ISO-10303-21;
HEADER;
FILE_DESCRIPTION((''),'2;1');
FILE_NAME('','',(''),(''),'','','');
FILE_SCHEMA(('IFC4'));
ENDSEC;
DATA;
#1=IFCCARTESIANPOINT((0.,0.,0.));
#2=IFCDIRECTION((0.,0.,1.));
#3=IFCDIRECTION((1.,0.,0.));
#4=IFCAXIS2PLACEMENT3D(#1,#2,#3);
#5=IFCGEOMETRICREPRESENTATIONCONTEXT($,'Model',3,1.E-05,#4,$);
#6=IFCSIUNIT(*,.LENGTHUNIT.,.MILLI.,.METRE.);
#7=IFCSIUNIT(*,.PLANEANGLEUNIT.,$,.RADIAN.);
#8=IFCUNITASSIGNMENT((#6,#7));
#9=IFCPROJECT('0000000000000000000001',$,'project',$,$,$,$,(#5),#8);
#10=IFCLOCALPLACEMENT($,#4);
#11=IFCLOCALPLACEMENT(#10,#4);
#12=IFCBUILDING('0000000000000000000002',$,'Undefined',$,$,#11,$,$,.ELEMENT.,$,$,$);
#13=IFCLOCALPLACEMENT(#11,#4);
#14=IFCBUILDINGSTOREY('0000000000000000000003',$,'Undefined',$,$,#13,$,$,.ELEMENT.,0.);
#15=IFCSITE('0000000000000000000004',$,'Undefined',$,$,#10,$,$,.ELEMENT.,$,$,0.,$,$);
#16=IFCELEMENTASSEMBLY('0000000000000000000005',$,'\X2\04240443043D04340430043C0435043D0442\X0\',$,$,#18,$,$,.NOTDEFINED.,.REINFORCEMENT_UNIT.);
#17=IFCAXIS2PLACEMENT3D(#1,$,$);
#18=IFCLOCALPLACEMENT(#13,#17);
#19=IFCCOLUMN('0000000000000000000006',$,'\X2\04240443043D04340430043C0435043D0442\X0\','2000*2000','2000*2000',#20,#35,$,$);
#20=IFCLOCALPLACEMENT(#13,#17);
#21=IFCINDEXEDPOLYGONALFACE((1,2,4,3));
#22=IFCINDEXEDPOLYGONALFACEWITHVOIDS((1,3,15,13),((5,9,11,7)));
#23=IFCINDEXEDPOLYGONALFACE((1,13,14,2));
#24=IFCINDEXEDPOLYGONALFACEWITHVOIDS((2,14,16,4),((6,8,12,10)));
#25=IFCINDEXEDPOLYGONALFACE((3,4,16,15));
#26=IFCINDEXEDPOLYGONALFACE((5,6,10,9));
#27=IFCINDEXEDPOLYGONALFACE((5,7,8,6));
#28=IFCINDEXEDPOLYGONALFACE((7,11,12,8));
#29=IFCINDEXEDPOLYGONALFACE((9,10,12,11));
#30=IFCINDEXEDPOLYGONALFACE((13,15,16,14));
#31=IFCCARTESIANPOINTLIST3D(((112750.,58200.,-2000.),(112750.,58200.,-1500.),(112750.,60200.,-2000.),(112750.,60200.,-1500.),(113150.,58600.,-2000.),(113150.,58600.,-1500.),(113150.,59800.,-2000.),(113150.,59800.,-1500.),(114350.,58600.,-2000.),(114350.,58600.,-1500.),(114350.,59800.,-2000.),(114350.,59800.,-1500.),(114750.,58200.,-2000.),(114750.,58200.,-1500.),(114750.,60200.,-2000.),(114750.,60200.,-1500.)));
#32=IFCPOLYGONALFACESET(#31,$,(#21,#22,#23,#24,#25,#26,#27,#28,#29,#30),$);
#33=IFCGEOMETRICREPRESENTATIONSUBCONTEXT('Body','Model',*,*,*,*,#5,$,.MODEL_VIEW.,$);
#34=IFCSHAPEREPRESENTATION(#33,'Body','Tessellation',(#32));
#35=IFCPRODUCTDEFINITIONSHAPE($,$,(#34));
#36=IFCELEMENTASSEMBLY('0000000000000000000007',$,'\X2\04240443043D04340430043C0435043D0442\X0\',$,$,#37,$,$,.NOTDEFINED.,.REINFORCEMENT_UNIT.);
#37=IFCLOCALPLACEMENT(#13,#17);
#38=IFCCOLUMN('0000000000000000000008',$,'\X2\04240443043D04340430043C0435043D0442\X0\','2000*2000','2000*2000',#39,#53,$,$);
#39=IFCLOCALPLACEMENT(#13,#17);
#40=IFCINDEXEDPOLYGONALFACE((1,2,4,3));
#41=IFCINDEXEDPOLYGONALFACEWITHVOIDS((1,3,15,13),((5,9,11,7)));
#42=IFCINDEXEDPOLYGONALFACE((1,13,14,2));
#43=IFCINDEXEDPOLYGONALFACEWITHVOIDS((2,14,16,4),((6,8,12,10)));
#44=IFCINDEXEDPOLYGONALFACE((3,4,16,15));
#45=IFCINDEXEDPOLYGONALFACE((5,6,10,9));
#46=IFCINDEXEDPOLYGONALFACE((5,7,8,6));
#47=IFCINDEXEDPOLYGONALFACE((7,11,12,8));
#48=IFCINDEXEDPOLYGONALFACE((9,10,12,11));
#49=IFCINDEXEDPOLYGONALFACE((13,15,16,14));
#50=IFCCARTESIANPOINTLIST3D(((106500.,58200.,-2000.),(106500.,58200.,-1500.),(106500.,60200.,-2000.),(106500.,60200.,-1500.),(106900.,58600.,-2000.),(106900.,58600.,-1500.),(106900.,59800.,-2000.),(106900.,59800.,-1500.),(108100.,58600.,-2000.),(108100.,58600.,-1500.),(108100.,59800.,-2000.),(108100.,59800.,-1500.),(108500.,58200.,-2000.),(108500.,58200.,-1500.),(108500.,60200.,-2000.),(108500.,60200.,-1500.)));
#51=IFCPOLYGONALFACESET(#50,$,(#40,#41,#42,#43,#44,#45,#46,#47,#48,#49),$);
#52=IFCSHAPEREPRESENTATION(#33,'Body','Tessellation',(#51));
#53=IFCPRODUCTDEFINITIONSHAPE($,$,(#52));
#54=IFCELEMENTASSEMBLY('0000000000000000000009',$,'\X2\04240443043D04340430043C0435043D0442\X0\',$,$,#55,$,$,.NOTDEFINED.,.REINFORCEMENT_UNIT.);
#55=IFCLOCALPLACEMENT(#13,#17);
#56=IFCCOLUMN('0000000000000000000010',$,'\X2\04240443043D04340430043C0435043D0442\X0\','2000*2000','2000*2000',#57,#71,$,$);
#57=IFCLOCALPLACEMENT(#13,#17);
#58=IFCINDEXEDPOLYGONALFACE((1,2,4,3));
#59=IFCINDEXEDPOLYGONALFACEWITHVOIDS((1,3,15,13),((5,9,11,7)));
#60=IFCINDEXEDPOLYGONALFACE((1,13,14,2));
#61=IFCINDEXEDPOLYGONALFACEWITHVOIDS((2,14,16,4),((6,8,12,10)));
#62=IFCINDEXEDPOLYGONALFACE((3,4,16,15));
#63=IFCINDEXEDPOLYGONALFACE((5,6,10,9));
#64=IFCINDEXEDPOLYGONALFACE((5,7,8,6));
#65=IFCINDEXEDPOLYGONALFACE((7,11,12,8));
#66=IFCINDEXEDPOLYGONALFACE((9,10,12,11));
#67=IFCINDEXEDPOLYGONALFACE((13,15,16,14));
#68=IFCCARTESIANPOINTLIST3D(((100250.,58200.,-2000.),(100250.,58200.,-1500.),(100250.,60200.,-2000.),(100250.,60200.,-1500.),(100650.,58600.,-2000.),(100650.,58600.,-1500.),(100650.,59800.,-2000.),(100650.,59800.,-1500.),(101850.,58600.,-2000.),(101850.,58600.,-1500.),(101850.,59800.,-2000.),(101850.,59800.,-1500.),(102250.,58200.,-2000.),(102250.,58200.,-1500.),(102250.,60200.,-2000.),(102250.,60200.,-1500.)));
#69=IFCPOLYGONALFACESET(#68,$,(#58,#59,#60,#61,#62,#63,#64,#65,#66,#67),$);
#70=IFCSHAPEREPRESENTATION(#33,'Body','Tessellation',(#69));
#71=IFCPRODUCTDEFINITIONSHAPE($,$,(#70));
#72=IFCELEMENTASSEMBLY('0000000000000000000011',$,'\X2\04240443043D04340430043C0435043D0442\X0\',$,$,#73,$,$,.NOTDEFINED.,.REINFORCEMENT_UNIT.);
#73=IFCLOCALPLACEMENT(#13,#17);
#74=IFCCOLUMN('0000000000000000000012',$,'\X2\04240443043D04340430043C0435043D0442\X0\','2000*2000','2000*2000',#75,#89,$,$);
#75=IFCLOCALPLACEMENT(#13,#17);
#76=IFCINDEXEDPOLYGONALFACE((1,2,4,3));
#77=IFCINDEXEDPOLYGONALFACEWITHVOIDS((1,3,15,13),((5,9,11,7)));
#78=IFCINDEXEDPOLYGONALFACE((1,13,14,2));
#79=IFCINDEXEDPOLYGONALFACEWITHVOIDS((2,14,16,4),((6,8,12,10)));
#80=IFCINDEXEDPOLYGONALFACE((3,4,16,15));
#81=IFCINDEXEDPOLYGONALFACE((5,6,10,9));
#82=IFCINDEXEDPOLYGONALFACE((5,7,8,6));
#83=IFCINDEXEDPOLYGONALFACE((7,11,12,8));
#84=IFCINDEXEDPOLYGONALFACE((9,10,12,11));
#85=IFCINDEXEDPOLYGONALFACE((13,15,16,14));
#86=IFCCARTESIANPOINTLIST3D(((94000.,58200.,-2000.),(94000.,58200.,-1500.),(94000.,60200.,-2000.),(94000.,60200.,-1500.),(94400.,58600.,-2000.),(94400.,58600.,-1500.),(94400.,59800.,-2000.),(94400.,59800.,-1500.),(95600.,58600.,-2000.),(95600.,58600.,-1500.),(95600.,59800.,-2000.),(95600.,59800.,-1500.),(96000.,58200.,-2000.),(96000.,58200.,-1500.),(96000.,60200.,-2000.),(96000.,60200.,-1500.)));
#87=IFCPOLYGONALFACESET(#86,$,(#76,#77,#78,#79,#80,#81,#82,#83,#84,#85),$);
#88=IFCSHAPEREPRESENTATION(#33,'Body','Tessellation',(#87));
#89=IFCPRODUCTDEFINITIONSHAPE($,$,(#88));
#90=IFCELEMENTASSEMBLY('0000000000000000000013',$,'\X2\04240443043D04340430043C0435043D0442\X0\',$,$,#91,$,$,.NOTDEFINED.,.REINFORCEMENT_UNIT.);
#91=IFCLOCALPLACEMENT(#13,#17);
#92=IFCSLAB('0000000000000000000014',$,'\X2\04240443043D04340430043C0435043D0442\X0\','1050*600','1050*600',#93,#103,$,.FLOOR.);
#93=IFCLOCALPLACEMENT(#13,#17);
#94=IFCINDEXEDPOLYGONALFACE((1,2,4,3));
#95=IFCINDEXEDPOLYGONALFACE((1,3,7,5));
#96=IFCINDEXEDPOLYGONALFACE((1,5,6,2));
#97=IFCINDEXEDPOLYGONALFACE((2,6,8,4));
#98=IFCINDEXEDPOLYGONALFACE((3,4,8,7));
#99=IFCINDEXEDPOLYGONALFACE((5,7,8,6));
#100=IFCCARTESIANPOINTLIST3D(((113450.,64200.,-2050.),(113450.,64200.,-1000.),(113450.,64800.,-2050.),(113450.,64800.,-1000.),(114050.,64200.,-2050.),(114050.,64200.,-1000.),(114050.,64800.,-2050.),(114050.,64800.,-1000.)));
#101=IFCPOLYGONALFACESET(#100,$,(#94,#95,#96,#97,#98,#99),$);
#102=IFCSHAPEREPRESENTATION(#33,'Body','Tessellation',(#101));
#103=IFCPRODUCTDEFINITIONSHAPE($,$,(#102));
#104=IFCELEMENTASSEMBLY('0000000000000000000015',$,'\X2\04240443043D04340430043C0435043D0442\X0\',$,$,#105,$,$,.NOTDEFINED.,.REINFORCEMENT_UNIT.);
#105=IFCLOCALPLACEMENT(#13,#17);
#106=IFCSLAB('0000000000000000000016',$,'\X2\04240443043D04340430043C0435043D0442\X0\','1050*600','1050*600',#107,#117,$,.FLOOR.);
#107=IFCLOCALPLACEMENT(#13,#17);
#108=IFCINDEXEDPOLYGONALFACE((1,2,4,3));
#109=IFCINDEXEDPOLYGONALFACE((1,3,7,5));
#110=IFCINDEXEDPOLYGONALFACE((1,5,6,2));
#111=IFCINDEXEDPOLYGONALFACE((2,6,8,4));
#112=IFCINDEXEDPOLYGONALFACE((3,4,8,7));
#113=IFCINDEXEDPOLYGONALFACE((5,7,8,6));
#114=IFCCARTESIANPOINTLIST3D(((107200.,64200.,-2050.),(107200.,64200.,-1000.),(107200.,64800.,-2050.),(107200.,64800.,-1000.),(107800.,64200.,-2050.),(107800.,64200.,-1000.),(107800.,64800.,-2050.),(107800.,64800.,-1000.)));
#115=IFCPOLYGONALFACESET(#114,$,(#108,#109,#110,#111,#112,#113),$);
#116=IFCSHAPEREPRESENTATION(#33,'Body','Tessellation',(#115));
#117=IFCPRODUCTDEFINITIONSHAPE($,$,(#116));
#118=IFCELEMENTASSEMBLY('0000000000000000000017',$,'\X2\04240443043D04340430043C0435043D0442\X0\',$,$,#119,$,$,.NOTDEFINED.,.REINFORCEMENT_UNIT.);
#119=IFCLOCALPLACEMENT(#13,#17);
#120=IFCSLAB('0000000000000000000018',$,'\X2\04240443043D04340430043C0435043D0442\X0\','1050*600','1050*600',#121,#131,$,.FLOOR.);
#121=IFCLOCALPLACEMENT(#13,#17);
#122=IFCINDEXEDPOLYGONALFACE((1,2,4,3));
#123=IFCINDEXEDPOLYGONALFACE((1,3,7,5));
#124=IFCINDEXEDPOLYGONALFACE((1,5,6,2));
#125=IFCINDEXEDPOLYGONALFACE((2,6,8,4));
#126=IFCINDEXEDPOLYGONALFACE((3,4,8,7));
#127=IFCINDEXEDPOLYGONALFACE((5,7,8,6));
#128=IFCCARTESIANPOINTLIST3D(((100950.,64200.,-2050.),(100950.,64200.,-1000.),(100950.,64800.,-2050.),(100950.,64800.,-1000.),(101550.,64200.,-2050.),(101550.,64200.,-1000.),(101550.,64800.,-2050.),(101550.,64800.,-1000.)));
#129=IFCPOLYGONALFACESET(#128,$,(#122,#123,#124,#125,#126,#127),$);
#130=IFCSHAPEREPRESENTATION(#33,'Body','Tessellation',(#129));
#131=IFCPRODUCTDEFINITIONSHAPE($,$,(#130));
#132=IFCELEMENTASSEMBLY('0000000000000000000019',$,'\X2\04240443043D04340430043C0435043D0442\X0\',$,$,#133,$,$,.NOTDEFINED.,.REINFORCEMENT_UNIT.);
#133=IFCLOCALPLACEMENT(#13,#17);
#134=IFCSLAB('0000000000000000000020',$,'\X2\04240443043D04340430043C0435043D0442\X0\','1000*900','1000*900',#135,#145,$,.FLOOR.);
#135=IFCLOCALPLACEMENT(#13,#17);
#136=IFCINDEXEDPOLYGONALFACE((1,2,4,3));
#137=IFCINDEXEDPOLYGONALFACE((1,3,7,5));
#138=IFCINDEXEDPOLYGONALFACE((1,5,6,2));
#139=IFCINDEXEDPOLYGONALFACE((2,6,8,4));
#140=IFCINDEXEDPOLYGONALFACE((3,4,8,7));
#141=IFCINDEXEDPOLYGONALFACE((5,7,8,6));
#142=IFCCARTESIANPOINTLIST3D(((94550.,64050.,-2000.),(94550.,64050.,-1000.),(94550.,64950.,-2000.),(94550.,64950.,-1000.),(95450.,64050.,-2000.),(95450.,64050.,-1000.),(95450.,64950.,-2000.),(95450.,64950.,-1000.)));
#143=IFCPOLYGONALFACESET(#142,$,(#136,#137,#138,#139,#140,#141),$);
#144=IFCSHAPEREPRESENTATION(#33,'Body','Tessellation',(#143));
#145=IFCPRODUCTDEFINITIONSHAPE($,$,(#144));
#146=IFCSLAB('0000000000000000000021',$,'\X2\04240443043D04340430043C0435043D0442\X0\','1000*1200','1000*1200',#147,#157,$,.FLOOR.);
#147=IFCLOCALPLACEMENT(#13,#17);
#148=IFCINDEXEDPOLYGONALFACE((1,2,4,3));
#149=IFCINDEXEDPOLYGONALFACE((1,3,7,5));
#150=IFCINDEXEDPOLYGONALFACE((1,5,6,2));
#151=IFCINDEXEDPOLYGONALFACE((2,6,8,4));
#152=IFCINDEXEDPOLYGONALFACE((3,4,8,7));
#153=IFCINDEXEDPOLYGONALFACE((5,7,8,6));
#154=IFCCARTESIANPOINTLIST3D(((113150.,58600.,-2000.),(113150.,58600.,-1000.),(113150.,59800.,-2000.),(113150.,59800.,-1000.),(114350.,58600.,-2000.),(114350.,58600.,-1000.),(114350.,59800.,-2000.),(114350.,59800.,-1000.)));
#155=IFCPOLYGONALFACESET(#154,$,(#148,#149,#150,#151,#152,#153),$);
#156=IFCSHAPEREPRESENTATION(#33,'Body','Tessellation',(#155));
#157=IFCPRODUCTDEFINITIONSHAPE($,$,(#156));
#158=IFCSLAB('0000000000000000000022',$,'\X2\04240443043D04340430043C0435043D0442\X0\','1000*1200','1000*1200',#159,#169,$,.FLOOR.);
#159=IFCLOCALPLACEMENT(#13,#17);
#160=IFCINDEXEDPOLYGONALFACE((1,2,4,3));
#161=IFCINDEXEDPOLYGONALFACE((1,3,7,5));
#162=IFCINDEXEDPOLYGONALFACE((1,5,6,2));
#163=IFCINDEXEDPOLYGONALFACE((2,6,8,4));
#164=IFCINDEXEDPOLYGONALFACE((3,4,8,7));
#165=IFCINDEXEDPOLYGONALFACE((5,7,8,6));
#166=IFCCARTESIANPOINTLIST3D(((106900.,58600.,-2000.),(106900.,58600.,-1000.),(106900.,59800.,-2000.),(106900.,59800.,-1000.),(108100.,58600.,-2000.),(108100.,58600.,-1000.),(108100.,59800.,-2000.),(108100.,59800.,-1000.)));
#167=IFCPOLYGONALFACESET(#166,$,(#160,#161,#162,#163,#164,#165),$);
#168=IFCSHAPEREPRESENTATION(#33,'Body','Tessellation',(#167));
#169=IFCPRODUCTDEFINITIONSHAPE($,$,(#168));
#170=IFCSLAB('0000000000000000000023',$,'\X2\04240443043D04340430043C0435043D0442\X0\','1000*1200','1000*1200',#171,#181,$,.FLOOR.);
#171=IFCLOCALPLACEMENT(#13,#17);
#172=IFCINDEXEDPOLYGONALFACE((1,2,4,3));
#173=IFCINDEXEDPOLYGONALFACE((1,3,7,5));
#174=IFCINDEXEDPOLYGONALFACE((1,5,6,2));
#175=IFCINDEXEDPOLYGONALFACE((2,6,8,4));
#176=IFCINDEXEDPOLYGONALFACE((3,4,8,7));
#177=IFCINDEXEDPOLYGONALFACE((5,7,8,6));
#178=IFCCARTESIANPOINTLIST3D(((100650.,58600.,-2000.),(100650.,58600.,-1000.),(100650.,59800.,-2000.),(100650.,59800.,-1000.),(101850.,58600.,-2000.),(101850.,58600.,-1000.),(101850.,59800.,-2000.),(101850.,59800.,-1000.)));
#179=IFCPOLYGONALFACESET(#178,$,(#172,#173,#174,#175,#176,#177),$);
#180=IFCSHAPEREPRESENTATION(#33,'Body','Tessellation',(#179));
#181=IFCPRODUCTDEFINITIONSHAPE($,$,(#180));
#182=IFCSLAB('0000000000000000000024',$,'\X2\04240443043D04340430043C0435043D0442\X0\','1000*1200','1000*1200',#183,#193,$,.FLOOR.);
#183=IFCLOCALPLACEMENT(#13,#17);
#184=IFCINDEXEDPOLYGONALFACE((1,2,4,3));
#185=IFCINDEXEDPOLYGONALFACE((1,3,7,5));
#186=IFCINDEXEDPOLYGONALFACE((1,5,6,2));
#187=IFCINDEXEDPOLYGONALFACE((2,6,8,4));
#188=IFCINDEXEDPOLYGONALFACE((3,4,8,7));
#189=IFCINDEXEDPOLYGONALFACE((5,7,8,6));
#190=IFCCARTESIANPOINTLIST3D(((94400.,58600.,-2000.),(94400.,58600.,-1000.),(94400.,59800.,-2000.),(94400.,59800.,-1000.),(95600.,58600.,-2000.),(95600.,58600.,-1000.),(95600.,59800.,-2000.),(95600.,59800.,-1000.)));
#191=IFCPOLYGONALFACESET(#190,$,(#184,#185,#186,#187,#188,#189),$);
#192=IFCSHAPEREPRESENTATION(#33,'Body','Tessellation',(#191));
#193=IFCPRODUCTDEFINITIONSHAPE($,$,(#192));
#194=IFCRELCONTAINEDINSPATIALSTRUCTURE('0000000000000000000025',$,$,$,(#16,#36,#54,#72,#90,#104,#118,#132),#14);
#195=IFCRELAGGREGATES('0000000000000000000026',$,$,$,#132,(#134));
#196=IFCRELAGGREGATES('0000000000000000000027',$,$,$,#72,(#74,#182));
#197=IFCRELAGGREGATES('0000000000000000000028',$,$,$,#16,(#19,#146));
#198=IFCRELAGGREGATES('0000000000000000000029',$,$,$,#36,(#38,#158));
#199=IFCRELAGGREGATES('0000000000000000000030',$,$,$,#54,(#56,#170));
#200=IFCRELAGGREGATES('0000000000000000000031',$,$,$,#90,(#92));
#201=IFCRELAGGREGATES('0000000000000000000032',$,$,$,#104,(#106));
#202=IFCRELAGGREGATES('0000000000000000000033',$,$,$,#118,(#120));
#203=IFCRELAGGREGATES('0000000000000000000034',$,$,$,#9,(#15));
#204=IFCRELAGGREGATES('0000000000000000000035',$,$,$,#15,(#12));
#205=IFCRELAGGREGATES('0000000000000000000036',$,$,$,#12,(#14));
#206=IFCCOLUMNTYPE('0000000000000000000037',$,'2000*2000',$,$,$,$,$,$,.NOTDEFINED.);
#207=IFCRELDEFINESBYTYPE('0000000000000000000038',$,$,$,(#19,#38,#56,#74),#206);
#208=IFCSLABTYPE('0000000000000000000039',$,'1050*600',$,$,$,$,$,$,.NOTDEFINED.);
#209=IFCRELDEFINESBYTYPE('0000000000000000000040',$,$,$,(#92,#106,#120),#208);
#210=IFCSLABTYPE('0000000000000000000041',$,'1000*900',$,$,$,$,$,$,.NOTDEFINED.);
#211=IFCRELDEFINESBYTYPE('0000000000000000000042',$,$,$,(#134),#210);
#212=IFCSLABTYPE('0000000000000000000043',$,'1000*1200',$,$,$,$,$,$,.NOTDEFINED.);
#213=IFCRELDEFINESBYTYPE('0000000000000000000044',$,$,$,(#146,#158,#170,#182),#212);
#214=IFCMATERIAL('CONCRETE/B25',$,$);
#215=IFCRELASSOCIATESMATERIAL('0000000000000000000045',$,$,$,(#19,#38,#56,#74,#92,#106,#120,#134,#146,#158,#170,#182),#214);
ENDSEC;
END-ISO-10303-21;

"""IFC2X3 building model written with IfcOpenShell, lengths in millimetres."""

from ifc_helpers import new_model, si_unit, frame, origin_with_axes, origin_2d_with_axis, place, context, subcontext, project, spatial, polyline, rectangle, outline, extrude, boolean, material, type_object, element, aggregate, save


model = new_model("IFC2X3")

# Units and contexts
model_context = context("Model", 3, precision=1e-05, world=origin_with_axes())
body_context = subcontext(model_context, "Body", "Model", "MODEL_VIEW")
ifc_project = project(units=[si_unit("LENGTHUNIT", "METRE", prefix="MILLI"), si_unit("PLANEANGLEUNIT", "RADIAN")], contexts=[model_context])

# Site, building, storey
site_placement = place(None, origin_with_axes())
site = spatial("IfcSite", under=ifc_project, at=site_placement, Name="Undefined", CompositionType="ELEMENT", RefElevation=0.0)
building_placement = place(site_placement, origin_with_axes())
building = spatial("IfcBuilding", under=site, at=building_placement, Name="Undefined", CompositionType="ELEMENT")
storey_placement = place(building_placement, origin_with_axes())
storey = spatial("IfcBuildingStorey", under=building, at=storey_placement, Name="Undefined", CompositionType="ELEMENT", Elevation=0.0)

# Element assemblies, columns
assembly_1_placement = place(storey_placement, origin_with_axes())
assembly_1 = element("IfcElementAssembly", 1, at=assembly_1_placement, inside=storey, Name="Фундамент", AssemblyPlace="NOTDEFINED", PredefinedType="REINFORCEMENT_UNIT")
ifc_material_1 = material(Name="CONCRETE/B25")
column_type = type_object("IfcColumnType", Name="2000*2000", PredefinedType="NOTDEFINED")
column_1_placement = place(assembly_1_placement, frame((113750.0, 59200.0, -2000.0), z_axis=(0.0, 0.0, 1.0), x_axis=(0.0, -1.0, 0.0)))
column_1 = element("IfcColumn", 2, at=column_1_placement, type_object=column_type, material=ifc_material_1, Name="Фундамент", Description="2000*2000", ObjectType="2000*2000", context=body_context, shape_type="CSG", body=[
    boolean("DIFFERENCE", extrude(rectangle(XDim=2000.0, YDim=2000.0, at=origin_2d_with_axis()), frame((0.0, 0.0, 500.0), z_axis=(0.0, 0.0, -1.0), x_axis=(0.0, 1.0, 0.0)), (0.0, 0.0, 1.0), 500.0), extrude(outline(polyline([(0.0, 0.0), (1200.0, 0.0), (1200.0, 1200.0), (0.0, 1200.0), (0.0, 0.0)])), frame((-600.0, -600.0, -100.0), z_axis=(0.0, 0.0, 1.0), x_axis=(1.0, 0.0, 0.0)), (0.0, 0.0, 1.0), 700.0)),
])
assembly_2_placement = place(storey_placement, origin_with_axes())
assembly_2 = element("IfcElementAssembly", 3, at=assembly_2_placement, inside=storey, Name="Фундамент", AssemblyPlace="NOTDEFINED", PredefinedType="REINFORCEMENT_UNIT")
column_2_placement = place(assembly_2_placement, frame((107500.0, 59200.0, -2000.0), z_axis=(0.0, 0.0, 1.0), x_axis=(0.0, -1.0, 0.0)))
column_2 = element("IfcColumn", 4, at=column_2_placement, type_object=column_type, material=ifc_material_1, Name="Фундамент", Description="2000*2000", ObjectType="2000*2000", context=body_context, shape_type="CSG", body=[
    boolean("DIFFERENCE", extrude(rectangle(XDim=2000.0, YDim=2000.0, at=origin_2d_with_axis()), frame((0.0, 0.0, 500.0), z_axis=(0.0, 0.0, -1.0), x_axis=(0.0, 1.0, 0.0)), (0.0, 0.0, 1.0), 500.0), extrude(outline(polyline([(0.0, 0.0), (1200.0, 0.0), (1200.0, 1200.0), (0.0, 1200.0), (0.0, 0.0)])), frame((-600.0, -600.0, -100.0), z_axis=(0.0, 0.0, 1.0), x_axis=(1.0, 0.0, 0.0)), (0.0, 0.0, 1.0), 700.0)),
])
assembly_3_placement = place(storey_placement, origin_with_axes())
assembly_3 = element("IfcElementAssembly", 5, at=assembly_3_placement, inside=storey, Name="Фундамент", AssemblyPlace="NOTDEFINED", PredefinedType="REINFORCEMENT_UNIT")
column_3_placement = place(assembly_3_placement, frame((101250.0, 59200.0, -2000.0), z_axis=(0.0, 0.0, 1.0), x_axis=(0.0, -1.0, 0.0)))
column_3 = element("IfcColumn", 6, at=column_3_placement, type_object=column_type, material=ifc_material_1, Name="Фундамент", Description="2000*2000", ObjectType="2000*2000", context=body_context, shape_type="CSG", body=[
    boolean("DIFFERENCE", extrude(rectangle(XDim=2000.0, YDim=2000.0, at=origin_2d_with_axis()), frame((0.0, 0.0, 500.0), z_axis=(0.0, 0.0, -1.0), x_axis=(0.0, 1.0, 0.0)), (0.0, 0.0, 1.0), 500.0), extrude(outline(polyline([(0.0, 0.0), (1200.0, 0.0), (1200.0, 1200.0), (0.0, 1200.0), (0.0, 0.0)])), frame((-600.0, -600.0, -100.0), z_axis=(0.0, 0.0, 1.0), x_axis=(1.0, 0.0, 0.0)), (0.0, 0.0, 1.0), 700.0)),
])
assembly_4_placement = place(storey_placement, origin_with_axes())
assembly_4 = element("IfcElementAssembly", 7, at=assembly_4_placement, inside=storey, Name="Фундамент", AssemblyPlace="NOTDEFINED", PredefinedType="REINFORCEMENT_UNIT")
column_4_placement = place(assembly_4_placement, frame((95000.0, 59200.0, -2000.0), z_axis=(0.0, 0.0, 1.0), x_axis=(0.0, -1.0, 0.0)))
column_4 = element("IfcColumn", 8, at=column_4_placement, type_object=column_type, material=ifc_material_1, Name="Фундамент", Description="2000*2000", ObjectType="2000*2000", context=body_context, shape_type="CSG", body=[
    boolean("DIFFERENCE", extrude(rectangle(XDim=2000.0, YDim=2000.0, at=origin_2d_with_axis()), frame((0.0, 0.0, 500.0), z_axis=(0.0, 0.0, -1.0), x_axis=(0.0, 1.0, 0.0)), (0.0, 0.0, 1.0), 500.0), extrude(outline(polyline([(0.0, 0.0), (1200.0, 0.0), (1200.0, 1200.0), (0.0, 1200.0), (0.0, 0.0)])), frame((-600.0, -600.0, -100.0), z_axis=(0.0, 0.0, 1.0), x_axis=(1.0, 0.0, 0.0)), (0.0, 0.0, 1.0), 700.0)),
])

# Element assemblies, slabs
assembly_5_placement = place(storey_placement, origin_with_axes())
assembly_5 = element("IfcElementAssembly", 9, at=assembly_5_placement, inside=storey, Name="Фундамент", AssemblyPlace="NOTDEFINED", PredefinedType="REINFORCEMENT_UNIT")
slab_type_1 = type_object("IfcSlabType", Name="1050*600", PredefinedType="NOTDEFINED")
slab_1_placement = place(assembly_5_placement, frame((113450.0, 64800.0, -1525.0), z_axis=(0.0, 0.0, 1.0), x_axis=(0.0, -1.0, 0.0)))
slab_1 = element("IfcSlab", 10, at=slab_1_placement, type_object=slab_type_1, material=ifc_material_1, Name="Фундамент", Description="1050*600", ObjectType="1050*600", PredefinedType="FLOOR", context=body_context, shape_type="SweptSolid", body=[
    extrude(outline(polyline([(0.0, 0.0), (600.0, 0.0), (600.0, 600.0), (0.0, 600.0), (0.0, 0.0)])), frame((0.0, 0.0, -525.0), z_axis=(0.0, 0.0, 1.0), x_axis=(1.0, 0.0, 0.0)), (0.0, 0.0, 1.0), 1050.0),
])
assembly_6_placement = place(storey_placement, origin_with_axes())
assembly_6 = element("IfcElementAssembly", 11, at=assembly_6_placement, inside=storey, Name="Фундамент", AssemblyPlace="NOTDEFINED", PredefinedType="REINFORCEMENT_UNIT")
slab_2_placement = place(assembly_6_placement, frame((107200.0, 64800.0, -1525.0), z_axis=(0.0, 0.0, 1.0), x_axis=(0.0, -1.0, 0.0)))
slab_2 = element("IfcSlab", 12, at=slab_2_placement, type_object=slab_type_1, material=ifc_material_1, Name="Фундамент", Description="1050*600", ObjectType="1050*600", PredefinedType="FLOOR", context=body_context, shape_type="SweptSolid", body=[
    extrude(outline(polyline([(0.0, 0.0), (600.0, 0.0), (600.0, 600.0), (0.0, 600.0), (0.0, 0.0)])), frame((0.0, 0.0, -525.0), z_axis=(0.0, 0.0, 1.0), x_axis=(1.0, 0.0, 0.0)), (0.0, 0.0, 1.0), 1050.0),
])
assembly_7_placement = place(storey_placement, origin_with_axes())
assembly_7 = element("IfcElementAssembly", 13, at=assembly_7_placement, inside=storey, Name="Фундамент", AssemblyPlace="NOTDEFINED", PredefinedType="REINFORCEMENT_UNIT")
slab_3_placement = place(assembly_7_placement, frame((100950.0, 64800.0, -1525.0), z_axis=(0.0, 0.0, 1.0), x_axis=(0.0, -1.0, 0.0)))
slab_3 = element("IfcSlab", 14, at=slab_3_placement, type_object=slab_type_1, material=ifc_material_1, Name="Фундамент", Description="1050*600", ObjectType="1050*600", PredefinedType="FLOOR", context=body_context, shape_type="SweptSolid", body=[
    extrude(outline(polyline([(0.0, 0.0), (600.0, 0.0), (600.0, 600.0), (0.0, 600.0), (0.0, 0.0)])), frame((0.0, 0.0, -525.0), z_axis=(0.0, 0.0, 1.0), x_axis=(1.0, 0.0, 0.0)), (0.0, 0.0, 1.0), 1050.0),
])
assembly_8_placement = place(storey_placement, origin_with_axes())
assembly_8 = element("IfcElementAssembly", 15, at=assembly_8_placement, inside=storey, Name="Фундамент", AssemblyPlace="NOTDEFINED", PredefinedType="REINFORCEMENT_UNIT")
slab_type_2 = type_object("IfcSlabType", Name="1000*900", PredefinedType="NOTDEFINED")
slab_4_placement = place(assembly_8_placement, frame((94550.0, 64950.0, -1500.0), z_axis=(0.0, 0.0, 1.0), x_axis=(0.0, -1.0, 0.0)))
slab_4 = element("IfcSlab", 16, at=slab_4_placement, type_object=slab_type_2, material=ifc_material_1, Name="Фундамент", Description="1000*900", ObjectType="1000*900", PredefinedType="FLOOR", context=body_context, shape_type="SweptSolid", body=[
    extrude(outline(polyline([(0.0, 0.0), (900.0, 0.0), (900.0, 900.0), (0.0, 900.0), (0.0, 0.0)])), frame((0.0, 0.0, -500.0), z_axis=(0.0, 0.0, 1.0), x_axis=(1.0, 0.0, 0.0)), (0.0, 0.0, 1.0), 1000.0),
])
aggregate(assembly_8, [slab_4])

# Slabs
slab_type_3 = type_object("IfcSlabType", Name="1000*1200", PredefinedType="NOTDEFINED")
slab_5_placement = place(assembly_1_placement, frame((113150.0, 59800.0, -1500.0), z_axis=(0.0, 0.0, 1.0), x_axis=(0.0, -1.0, 0.0)))
slab_5 = element("IfcSlab", 17, at=slab_5_placement, type_object=slab_type_3, material=ifc_material_1, Name="Фундамент", Description="1000*1200", ObjectType="1000*1200", PredefinedType="FLOOR", context=body_context, shape_type="SweptSolid", body=[
    extrude(outline(polyline([(0.0, 0.0), (1200.0, 0.0), (1200.0, 1200.0), (0.0, 1200.0), (0.0, 0.0)])), frame((0.0, 0.0, -500.0), z_axis=(0.0, 0.0, 1.0), x_axis=(1.0, 0.0, 0.0)), (0.0, 0.0, 1.0), 1000.0),
])
slab_6_placement = place(assembly_2_placement, frame((106900.0, 59800.0, -1500.0), z_axis=(0.0, 0.0, 1.0), x_axis=(0.0, -1.0, 0.0)))
slab_6 = element("IfcSlab", 18, at=slab_6_placement, type_object=slab_type_3, material=ifc_material_1, Name="Фундамент", Description="1000*1200", ObjectType="1000*1200", PredefinedType="FLOOR", context=body_context, shape_type="SweptSolid", body=[
    extrude(outline(polyline([(0.0, 0.0), (1200.0, 0.0), (1200.0, 1200.0), (0.0, 1200.0), (0.0, 0.0)])), frame((0.0, 0.0, -500.0), z_axis=(0.0, 0.0, 1.0), x_axis=(1.0, 0.0, 0.0)), (0.0, 0.0, 1.0), 1000.0),
])
slab_7_placement = place(assembly_3_placement, frame((100650.0, 59800.0, -1500.0), z_axis=(0.0, 0.0, 1.0), x_axis=(0.0, -1.0, 0.0)))
slab_7 = element("IfcSlab", 19, at=slab_7_placement, type_object=slab_type_3, material=ifc_material_1, Name="Фундамент", Description="1000*1200", ObjectType="1000*1200", PredefinedType="FLOOR", context=body_context, shape_type="SweptSolid", body=[
    extrude(outline(polyline([(0.0, 0.0), (1200.0, 0.0), (1200.0, 1200.0), (0.0, 1200.0), (0.0, 0.0)])), frame((0.0, 0.0, -500.0), z_axis=(0.0, 0.0, 1.0), x_axis=(1.0, 0.0, 0.0)), (0.0, 0.0, 1.0), 1000.0),
])
slab_8_placement = place(assembly_4_placement, frame((94400.0, 59800.0, -1500.0), z_axis=(0.0, 0.0, 1.0), x_axis=(0.0, -1.0, 0.0)))
slab_8 = element("IfcSlab", 20, at=slab_8_placement, type_object=slab_type_3, material=ifc_material_1, Name="Фундамент", Description="1000*1200", ObjectType="1000*1200", PredefinedType="FLOOR", context=body_context, shape_type="SweptSolid", body=[
    extrude(outline(polyline([(0.0, 0.0), (1200.0, 0.0), (1200.0, 1200.0), (0.0, 1200.0), (0.0, 0.0)])), frame((0.0, 0.0, -500.0), z_axis=(0.0, 0.0, 1.0), x_axis=(1.0, 0.0, 0.0)), (0.0, 0.0, 1.0), 1000.0),
])
aggregate(assembly_4, [column_4, slab_8])
aggregate(assembly_1, [column_1, slab_5])
aggregate(assembly_2, [column_2, slab_6])
aggregate(assembly_3, [column_3, slab_7])
aggregate(assembly_5, [slab_1])
aggregate(assembly_6, [slab_2])
aggregate(assembly_7, [slab_3])

save(model, "model.ifc")
